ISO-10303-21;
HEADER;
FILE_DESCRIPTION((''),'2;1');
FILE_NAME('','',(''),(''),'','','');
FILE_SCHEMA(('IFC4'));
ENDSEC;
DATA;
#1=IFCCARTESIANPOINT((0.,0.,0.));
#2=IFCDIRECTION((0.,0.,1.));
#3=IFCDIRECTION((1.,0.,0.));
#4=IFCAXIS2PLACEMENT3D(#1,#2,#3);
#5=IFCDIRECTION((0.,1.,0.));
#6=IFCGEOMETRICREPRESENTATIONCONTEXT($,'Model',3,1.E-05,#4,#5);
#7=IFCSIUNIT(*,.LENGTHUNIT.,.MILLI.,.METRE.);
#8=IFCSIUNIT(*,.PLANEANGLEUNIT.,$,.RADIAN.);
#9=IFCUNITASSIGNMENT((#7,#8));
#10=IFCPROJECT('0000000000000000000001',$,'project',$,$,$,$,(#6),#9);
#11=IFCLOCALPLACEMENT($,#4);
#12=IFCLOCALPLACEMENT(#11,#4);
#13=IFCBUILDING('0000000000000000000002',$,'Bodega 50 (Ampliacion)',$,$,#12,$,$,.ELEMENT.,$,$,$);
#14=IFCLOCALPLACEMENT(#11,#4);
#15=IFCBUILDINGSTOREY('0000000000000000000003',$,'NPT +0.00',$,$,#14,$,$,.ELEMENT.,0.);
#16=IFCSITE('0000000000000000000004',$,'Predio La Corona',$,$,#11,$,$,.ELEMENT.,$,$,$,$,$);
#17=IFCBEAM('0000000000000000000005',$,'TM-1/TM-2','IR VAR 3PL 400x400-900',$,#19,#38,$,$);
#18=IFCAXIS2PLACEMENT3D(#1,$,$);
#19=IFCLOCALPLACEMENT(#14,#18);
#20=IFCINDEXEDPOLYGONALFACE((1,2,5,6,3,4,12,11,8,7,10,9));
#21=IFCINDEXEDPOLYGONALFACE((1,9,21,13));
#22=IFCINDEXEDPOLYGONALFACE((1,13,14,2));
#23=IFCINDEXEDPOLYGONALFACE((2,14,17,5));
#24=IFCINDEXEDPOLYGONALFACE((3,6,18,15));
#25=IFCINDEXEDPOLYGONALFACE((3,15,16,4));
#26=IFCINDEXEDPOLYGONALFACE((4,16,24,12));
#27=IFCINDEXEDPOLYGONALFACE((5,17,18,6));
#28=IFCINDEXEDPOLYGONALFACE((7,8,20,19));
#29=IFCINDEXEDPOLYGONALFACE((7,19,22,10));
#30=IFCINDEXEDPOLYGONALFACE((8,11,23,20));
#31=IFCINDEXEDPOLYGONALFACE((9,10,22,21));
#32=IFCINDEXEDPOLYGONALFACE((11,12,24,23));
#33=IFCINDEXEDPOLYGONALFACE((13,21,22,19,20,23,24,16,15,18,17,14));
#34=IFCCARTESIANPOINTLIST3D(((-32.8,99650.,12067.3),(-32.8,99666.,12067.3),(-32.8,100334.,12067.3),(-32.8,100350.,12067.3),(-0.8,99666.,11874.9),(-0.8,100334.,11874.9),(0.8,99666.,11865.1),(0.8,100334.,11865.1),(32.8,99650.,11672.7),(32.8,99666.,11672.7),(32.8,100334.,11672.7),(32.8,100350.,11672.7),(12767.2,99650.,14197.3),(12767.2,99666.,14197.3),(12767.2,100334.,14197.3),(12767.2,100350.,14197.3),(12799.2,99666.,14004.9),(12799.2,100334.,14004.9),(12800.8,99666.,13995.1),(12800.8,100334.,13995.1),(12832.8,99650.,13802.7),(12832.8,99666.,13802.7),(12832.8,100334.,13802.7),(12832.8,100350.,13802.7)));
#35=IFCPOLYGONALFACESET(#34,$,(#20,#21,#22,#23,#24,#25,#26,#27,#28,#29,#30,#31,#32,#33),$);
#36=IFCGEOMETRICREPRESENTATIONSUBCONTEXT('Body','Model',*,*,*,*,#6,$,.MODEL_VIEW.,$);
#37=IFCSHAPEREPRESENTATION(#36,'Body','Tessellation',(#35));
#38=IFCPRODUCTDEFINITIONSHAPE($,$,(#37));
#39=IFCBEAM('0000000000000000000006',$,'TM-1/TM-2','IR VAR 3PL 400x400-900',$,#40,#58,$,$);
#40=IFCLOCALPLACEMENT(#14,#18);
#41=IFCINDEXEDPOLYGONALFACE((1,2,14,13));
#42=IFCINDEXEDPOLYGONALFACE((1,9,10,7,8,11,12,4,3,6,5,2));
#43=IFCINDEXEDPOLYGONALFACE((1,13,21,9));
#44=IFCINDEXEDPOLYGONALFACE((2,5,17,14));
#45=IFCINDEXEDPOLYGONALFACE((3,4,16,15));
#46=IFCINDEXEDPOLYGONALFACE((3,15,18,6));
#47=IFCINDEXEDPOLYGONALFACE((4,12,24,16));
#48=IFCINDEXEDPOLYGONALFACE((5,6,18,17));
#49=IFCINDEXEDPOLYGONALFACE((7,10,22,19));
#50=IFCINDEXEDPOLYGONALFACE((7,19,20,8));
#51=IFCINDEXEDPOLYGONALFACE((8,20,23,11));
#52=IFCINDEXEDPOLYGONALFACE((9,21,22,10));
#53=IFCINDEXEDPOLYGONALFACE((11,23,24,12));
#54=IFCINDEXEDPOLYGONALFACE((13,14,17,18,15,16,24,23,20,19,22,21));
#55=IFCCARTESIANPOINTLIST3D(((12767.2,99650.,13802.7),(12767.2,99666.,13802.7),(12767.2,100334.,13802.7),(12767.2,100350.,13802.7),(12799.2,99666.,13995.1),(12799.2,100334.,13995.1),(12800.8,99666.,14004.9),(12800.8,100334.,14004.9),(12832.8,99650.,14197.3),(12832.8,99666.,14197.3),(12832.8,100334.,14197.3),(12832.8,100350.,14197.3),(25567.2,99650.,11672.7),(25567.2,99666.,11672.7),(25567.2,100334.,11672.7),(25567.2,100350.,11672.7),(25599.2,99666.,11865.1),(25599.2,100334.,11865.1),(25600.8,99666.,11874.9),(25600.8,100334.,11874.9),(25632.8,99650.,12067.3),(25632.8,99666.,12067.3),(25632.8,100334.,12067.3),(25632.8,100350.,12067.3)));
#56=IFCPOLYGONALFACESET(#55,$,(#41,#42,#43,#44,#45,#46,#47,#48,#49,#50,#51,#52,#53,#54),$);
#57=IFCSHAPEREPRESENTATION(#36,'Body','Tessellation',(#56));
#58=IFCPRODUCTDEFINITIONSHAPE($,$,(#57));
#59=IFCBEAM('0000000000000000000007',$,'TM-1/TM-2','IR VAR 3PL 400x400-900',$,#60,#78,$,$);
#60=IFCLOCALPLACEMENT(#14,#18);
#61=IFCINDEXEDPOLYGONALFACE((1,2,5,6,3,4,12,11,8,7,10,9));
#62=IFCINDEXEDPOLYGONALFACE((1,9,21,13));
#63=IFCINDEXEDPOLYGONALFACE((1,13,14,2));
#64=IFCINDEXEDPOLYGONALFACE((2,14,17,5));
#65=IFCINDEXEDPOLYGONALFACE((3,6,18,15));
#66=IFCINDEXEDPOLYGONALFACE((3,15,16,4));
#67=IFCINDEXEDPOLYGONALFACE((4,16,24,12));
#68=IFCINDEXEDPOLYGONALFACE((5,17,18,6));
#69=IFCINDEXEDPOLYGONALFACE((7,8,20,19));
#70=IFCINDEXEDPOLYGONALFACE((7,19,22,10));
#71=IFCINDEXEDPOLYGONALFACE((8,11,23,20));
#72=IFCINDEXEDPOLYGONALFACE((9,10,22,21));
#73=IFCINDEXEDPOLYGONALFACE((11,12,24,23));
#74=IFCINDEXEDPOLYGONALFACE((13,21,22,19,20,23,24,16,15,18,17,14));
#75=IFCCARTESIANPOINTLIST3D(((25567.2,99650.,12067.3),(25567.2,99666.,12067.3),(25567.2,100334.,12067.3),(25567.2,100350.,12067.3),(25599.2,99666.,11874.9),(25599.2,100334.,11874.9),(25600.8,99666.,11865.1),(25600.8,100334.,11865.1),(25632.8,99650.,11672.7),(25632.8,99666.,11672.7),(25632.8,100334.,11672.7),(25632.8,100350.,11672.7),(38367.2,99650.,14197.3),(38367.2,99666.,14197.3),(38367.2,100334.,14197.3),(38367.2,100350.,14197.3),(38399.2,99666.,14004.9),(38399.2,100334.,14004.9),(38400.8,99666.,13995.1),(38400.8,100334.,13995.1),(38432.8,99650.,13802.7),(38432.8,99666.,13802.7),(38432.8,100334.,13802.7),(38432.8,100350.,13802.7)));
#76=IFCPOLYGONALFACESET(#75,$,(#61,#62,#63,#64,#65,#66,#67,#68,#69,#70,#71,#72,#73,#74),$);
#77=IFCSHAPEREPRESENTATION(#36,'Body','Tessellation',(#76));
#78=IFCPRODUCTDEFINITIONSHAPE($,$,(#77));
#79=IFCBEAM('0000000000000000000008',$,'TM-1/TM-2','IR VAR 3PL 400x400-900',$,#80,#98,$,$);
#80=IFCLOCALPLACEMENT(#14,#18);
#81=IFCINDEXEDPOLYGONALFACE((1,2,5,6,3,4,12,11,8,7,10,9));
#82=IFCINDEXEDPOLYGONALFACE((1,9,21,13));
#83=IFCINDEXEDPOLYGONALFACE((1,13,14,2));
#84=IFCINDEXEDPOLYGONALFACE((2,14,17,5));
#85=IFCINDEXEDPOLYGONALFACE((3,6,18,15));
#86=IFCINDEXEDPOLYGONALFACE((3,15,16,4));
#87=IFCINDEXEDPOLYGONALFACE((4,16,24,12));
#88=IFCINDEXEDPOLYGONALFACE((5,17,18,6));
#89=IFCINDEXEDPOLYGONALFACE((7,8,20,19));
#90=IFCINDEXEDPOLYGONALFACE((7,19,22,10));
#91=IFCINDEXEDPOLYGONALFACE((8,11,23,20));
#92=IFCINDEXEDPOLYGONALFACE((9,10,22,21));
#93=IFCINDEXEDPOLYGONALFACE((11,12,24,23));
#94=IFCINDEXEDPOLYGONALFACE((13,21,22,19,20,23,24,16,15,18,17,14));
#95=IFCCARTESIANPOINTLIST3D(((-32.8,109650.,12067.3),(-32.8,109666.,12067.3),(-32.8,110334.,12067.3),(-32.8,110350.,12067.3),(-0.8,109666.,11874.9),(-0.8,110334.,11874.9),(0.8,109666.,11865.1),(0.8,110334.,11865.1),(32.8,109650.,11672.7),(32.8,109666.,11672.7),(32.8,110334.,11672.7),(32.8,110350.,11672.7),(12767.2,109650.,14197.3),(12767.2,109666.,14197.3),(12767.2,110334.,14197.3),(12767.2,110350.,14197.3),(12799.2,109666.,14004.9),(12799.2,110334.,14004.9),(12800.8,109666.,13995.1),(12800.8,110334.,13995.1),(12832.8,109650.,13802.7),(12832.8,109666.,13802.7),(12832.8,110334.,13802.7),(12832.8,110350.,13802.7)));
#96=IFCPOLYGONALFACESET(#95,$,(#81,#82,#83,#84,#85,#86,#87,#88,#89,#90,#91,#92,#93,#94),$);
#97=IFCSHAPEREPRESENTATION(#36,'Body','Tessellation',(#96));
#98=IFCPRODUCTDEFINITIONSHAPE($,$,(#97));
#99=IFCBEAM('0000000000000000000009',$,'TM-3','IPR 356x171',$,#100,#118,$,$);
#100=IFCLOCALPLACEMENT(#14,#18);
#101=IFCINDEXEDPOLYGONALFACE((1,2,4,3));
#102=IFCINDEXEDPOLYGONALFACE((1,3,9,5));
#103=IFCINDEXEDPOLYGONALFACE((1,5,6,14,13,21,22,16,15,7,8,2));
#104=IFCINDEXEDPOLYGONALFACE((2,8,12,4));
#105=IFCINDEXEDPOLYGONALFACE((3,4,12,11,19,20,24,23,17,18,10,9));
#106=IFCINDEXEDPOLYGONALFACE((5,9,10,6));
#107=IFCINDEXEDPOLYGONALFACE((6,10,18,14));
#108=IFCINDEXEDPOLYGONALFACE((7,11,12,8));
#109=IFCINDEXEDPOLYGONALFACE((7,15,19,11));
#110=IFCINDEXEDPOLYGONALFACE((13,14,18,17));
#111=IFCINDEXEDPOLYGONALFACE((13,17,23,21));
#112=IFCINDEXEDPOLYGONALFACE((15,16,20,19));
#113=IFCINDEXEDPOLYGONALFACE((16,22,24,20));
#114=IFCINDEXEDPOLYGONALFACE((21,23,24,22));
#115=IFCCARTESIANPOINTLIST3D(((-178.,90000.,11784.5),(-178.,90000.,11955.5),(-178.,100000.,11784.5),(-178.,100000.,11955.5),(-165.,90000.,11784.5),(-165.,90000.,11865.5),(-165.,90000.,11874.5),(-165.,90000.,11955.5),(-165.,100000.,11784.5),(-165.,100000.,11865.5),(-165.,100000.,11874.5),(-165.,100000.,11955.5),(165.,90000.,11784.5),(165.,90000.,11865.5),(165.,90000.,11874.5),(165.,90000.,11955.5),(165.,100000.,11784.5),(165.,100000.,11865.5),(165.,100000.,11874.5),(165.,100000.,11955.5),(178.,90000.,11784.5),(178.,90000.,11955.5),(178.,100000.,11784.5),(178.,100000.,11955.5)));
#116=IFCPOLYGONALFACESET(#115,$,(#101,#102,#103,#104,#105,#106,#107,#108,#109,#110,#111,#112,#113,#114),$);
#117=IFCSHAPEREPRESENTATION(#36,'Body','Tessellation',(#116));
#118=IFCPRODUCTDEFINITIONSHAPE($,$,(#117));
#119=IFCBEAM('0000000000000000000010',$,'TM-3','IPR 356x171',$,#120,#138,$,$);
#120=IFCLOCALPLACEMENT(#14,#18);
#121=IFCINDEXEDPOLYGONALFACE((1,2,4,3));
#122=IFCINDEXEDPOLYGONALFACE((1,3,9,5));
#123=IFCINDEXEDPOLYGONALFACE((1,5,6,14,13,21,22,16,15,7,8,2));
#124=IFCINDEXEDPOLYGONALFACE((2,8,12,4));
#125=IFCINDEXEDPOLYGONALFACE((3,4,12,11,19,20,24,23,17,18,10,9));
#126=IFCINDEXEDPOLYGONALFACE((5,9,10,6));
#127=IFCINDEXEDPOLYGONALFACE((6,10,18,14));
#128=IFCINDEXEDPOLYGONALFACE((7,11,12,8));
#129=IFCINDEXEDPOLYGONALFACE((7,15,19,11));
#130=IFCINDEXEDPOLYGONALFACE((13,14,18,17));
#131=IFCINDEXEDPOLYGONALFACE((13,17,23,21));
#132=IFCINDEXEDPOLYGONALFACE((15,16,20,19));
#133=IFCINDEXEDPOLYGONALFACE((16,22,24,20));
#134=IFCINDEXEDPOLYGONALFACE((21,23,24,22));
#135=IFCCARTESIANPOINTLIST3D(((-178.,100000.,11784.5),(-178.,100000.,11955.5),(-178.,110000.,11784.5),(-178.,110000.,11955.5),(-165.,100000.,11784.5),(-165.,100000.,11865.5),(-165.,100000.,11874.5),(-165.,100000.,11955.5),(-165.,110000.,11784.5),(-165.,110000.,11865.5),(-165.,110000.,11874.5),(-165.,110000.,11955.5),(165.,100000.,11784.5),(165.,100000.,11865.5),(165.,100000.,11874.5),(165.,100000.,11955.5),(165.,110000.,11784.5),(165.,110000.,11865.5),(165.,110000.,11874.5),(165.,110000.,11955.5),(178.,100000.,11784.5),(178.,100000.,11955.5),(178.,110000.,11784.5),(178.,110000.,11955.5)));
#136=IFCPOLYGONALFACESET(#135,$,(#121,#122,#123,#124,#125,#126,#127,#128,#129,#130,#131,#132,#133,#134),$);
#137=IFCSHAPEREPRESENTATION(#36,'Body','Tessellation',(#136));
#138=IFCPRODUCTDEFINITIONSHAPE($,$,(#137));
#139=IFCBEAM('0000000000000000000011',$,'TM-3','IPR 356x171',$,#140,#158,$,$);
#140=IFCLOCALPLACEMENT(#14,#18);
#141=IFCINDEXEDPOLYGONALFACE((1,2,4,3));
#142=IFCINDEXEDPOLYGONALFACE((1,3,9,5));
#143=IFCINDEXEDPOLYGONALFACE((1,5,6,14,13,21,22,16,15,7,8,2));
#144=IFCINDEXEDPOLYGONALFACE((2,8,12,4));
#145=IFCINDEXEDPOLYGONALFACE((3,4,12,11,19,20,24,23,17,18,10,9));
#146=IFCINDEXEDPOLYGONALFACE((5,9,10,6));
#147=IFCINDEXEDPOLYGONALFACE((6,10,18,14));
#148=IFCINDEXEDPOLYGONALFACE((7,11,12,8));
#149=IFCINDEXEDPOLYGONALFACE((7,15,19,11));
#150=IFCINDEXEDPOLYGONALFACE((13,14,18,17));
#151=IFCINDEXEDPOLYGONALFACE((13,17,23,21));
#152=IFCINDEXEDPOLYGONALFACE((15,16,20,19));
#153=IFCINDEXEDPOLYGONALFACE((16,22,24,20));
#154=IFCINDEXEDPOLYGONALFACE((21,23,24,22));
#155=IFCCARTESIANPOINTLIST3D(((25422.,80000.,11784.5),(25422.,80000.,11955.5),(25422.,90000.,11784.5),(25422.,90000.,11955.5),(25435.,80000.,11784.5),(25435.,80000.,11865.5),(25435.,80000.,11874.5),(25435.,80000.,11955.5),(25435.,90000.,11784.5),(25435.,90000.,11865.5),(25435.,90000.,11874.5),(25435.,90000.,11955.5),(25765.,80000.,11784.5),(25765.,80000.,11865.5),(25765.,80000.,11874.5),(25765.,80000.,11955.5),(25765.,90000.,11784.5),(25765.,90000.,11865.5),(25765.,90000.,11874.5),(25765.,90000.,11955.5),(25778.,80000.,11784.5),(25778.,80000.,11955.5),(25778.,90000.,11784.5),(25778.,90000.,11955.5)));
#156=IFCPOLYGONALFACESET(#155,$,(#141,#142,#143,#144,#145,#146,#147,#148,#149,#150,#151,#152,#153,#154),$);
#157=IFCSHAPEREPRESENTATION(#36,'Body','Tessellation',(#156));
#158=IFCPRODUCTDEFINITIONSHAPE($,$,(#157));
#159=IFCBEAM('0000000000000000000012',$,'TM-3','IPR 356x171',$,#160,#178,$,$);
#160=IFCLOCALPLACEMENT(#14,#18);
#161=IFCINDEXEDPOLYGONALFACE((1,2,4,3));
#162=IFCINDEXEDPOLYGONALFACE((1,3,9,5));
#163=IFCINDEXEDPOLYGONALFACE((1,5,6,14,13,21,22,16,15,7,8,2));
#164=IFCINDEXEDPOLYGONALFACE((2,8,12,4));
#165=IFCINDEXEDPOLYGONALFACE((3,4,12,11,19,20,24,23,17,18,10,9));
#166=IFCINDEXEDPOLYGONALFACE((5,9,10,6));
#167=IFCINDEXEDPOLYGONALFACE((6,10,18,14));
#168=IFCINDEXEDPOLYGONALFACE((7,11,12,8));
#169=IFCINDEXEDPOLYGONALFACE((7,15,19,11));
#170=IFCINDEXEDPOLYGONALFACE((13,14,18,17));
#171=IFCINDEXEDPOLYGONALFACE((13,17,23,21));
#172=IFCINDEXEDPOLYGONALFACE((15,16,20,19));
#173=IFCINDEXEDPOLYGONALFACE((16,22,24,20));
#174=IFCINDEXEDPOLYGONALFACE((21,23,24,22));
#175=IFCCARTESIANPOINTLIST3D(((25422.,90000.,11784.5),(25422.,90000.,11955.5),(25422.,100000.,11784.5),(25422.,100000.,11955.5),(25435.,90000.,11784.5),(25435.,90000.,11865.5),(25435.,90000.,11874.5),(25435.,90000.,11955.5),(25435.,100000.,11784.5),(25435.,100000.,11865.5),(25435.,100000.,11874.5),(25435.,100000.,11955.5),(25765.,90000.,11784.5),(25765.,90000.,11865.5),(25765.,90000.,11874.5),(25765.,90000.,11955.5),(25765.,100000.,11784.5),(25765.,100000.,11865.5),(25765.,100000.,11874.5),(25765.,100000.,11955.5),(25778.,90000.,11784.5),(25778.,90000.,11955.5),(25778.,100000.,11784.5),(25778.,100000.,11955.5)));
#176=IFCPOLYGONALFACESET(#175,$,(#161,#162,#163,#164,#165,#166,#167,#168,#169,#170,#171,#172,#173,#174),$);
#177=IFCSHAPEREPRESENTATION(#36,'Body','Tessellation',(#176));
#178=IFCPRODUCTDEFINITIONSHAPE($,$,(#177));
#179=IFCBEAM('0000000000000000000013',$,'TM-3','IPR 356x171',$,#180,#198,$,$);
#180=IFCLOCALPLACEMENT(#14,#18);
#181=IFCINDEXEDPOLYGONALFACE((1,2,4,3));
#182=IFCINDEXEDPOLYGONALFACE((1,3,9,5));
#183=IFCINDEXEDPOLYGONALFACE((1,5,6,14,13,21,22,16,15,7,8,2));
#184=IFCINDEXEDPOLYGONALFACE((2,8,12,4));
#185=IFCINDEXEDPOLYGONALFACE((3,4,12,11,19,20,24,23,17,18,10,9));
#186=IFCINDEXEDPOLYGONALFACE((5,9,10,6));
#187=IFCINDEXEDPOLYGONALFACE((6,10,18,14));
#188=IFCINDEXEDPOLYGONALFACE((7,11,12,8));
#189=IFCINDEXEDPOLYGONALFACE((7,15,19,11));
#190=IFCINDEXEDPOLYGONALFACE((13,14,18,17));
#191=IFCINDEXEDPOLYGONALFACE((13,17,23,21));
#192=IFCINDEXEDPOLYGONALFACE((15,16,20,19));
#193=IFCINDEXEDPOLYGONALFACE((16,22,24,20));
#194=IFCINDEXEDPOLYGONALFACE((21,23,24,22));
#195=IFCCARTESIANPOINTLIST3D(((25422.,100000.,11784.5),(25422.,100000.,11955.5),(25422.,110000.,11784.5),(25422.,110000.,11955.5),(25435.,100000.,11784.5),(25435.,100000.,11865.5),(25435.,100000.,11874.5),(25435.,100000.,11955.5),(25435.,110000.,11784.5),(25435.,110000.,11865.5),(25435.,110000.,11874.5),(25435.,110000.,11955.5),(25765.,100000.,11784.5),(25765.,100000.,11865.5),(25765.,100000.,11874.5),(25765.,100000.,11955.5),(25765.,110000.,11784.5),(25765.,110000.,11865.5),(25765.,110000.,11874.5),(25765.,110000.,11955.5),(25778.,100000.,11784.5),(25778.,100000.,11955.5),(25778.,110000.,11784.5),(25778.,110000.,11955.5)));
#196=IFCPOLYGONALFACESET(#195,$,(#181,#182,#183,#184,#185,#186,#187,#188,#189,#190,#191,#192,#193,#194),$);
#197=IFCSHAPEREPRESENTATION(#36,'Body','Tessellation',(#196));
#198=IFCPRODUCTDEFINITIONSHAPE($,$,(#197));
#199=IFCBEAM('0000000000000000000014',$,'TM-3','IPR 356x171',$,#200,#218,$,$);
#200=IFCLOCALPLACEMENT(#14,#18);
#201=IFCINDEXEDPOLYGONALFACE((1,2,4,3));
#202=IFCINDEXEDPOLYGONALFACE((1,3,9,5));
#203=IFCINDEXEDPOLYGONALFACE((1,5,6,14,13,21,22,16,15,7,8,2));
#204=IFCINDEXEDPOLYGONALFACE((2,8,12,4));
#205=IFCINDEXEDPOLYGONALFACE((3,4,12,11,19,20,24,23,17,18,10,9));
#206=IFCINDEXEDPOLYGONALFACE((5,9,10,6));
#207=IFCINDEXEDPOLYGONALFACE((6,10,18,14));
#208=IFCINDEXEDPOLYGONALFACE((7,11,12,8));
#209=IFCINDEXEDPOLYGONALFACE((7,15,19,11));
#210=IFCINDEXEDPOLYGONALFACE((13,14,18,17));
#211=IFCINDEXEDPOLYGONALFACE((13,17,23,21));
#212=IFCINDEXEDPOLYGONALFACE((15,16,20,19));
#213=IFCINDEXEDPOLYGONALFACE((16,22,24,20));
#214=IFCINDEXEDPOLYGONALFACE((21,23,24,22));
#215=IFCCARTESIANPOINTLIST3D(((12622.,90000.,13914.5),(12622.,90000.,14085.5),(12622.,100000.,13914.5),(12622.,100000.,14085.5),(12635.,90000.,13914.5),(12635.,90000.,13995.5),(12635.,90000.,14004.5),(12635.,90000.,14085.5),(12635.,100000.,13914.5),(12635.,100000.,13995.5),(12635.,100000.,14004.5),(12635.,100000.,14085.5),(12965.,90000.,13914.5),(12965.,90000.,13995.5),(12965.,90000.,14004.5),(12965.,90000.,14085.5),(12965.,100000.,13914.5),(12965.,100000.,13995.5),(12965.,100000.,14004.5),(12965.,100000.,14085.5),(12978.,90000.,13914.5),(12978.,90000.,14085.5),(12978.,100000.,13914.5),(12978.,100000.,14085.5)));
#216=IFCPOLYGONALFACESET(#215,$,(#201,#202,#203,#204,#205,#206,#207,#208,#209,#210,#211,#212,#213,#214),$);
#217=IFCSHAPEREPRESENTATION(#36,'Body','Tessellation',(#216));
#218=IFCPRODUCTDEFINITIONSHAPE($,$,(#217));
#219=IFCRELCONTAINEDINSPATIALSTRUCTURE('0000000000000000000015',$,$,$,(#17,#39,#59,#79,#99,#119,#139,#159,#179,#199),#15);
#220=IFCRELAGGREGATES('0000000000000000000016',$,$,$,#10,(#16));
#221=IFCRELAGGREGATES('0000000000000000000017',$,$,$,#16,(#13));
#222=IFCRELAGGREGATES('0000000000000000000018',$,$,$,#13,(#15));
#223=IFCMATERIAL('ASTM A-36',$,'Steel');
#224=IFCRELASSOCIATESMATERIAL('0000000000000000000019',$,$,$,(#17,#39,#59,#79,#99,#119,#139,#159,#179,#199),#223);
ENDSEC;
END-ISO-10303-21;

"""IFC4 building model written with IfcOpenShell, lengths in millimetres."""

from ifc_helpers import new_model, si_unit, direction, frame, origin_with_axes, origin_2d, place, context, subcontext, project, spatial, i_section, extrude, material, element, save


model = new_model("IFC4")

# Units and contexts
model_context = context("Model", 3, precision=1e-05, world=origin_with_axes(), true_north=direction((0.0, 1.0, 0.0)))
body_context = subcontext(model_context, "Body", "Model", "MODEL_VIEW")
ifc_project = project(units=[si_unit("LENGTHUNIT", "METRE", prefix="MILLI"), si_unit("PLANEANGLEUNIT", "RADIAN")], contexts=[model_context])

# Site, building, storey
site_placement = place(None, origin_with_axes())
site = spatial("IfcSite", under=ifc_project, at=site_placement, Name="Predio La Corona", CompositionType="ELEMENT")
building_placement = place(site_placement, origin_with_axes())
building = spatial("IfcBuilding", under=site, at=building_placement, Name="Bodega 50 (Ampliacion)", CompositionType="ELEMENT")
storey_placement = place(site_placement, origin_with_axes())
storey = spatial("IfcBuildingStorey", under=building, at=storey_placement, Name="NPT +0.00", CompositionType="ELEMENT", Elevation=0.0)

# Shared definitions
ifc_material = material(Name="ASTM A-36", Category="Steel")

# Beams
for number, where, z_axis, x_axis, name in (
    (1, (0.0, 100000.0, 11870.0), (0.986436, 0.0, 0.164149), (0.164149, 0.0, -0.986436), "TM-1/TM-2"),
    (2, (12800.0, 100000.0, 14000.0), (0.986436, 0.0, -0.164149), (-0.164149, 0.0, -0.986436), "TM-1/TM-2"),
    (3, (25600.0, 100000.0, 11870.0), (0.986436, 0.0, 0.164149), (0.164149, 0.0, -0.986436), "TM-1/TM-2"),
    (4, (0.0, 110000.0, 11870.0), (0.986436, 0.0, 0.164149), (0.164149, 0.0, -0.986436), "TM-1/TM-2"),
):
    element("IfcBeam", number, at=place(storey_placement, frame(where, z_axis=z_axis, x_axis=x_axis)), inside=storey, material=ifc_material, Name=name, Description="IR VAR 3PL 400x400-900", context=body_context, shape_type="SweptSolid", body=[
        extrude(i_section(OverallWidth=400.0, OverallDepth=700.0, WebThickness=10.0, FlangeThickness=16.0, at=origin_2d()), origin_with_axes(), (0.0, 0.0, 1.0), 12976.0),
    ])
for number, where, z_axis, x_axis, name in (
    (5, (0.0, 90000.0, 11870.0), (0.0, 1.0, 0.0), (0.0, 0.0, 1.0), "TM-3"),
    (6, (0.0, 100000.0, 11870.0), (0.0, 1.0, 0.0), (0.0, 0.0, 1.0), "TM-3"),
    (7, (25600.0, 80000.0, 11870.0), (0.0, 1.0, 0.0), (0.0, 0.0, 1.0), "TM-3"),
    (8, (25600.0, 90000.0, 11870.0), (0.0, 1.0, 0.0), (0.0, 0.0, 1.0), "TM-3"),
    (9, (25600.0, 100000.0, 11870.0), (0.0, 1.0, 0.0), (0.0, 0.0, 1.0), "TM-3"),
    (10, (12800.0, 90000.0, 14000.0), (0.0, 1.0, 0.0), (0.0, 0.0, 1.0), "TM-3"),
):
    element("IfcBeam", number, at=place(storey_placement, frame(where, z_axis=z_axis, x_axis=x_axis)), inside=storey, material=ifc_material, Name=name, Description="IPR 356x171", context=body_context, shape_type="SweptSolid", body=[
        extrude(i_section(OverallWidth=171.0, OverallDepth=356.0, WebThickness=9.0, FlangeThickness=13.0, at=origin_2d()), origin_with_axes(), (0.0, 0.0, 1.0), 10000.0),
    ])

save(model, "model.ifc")
